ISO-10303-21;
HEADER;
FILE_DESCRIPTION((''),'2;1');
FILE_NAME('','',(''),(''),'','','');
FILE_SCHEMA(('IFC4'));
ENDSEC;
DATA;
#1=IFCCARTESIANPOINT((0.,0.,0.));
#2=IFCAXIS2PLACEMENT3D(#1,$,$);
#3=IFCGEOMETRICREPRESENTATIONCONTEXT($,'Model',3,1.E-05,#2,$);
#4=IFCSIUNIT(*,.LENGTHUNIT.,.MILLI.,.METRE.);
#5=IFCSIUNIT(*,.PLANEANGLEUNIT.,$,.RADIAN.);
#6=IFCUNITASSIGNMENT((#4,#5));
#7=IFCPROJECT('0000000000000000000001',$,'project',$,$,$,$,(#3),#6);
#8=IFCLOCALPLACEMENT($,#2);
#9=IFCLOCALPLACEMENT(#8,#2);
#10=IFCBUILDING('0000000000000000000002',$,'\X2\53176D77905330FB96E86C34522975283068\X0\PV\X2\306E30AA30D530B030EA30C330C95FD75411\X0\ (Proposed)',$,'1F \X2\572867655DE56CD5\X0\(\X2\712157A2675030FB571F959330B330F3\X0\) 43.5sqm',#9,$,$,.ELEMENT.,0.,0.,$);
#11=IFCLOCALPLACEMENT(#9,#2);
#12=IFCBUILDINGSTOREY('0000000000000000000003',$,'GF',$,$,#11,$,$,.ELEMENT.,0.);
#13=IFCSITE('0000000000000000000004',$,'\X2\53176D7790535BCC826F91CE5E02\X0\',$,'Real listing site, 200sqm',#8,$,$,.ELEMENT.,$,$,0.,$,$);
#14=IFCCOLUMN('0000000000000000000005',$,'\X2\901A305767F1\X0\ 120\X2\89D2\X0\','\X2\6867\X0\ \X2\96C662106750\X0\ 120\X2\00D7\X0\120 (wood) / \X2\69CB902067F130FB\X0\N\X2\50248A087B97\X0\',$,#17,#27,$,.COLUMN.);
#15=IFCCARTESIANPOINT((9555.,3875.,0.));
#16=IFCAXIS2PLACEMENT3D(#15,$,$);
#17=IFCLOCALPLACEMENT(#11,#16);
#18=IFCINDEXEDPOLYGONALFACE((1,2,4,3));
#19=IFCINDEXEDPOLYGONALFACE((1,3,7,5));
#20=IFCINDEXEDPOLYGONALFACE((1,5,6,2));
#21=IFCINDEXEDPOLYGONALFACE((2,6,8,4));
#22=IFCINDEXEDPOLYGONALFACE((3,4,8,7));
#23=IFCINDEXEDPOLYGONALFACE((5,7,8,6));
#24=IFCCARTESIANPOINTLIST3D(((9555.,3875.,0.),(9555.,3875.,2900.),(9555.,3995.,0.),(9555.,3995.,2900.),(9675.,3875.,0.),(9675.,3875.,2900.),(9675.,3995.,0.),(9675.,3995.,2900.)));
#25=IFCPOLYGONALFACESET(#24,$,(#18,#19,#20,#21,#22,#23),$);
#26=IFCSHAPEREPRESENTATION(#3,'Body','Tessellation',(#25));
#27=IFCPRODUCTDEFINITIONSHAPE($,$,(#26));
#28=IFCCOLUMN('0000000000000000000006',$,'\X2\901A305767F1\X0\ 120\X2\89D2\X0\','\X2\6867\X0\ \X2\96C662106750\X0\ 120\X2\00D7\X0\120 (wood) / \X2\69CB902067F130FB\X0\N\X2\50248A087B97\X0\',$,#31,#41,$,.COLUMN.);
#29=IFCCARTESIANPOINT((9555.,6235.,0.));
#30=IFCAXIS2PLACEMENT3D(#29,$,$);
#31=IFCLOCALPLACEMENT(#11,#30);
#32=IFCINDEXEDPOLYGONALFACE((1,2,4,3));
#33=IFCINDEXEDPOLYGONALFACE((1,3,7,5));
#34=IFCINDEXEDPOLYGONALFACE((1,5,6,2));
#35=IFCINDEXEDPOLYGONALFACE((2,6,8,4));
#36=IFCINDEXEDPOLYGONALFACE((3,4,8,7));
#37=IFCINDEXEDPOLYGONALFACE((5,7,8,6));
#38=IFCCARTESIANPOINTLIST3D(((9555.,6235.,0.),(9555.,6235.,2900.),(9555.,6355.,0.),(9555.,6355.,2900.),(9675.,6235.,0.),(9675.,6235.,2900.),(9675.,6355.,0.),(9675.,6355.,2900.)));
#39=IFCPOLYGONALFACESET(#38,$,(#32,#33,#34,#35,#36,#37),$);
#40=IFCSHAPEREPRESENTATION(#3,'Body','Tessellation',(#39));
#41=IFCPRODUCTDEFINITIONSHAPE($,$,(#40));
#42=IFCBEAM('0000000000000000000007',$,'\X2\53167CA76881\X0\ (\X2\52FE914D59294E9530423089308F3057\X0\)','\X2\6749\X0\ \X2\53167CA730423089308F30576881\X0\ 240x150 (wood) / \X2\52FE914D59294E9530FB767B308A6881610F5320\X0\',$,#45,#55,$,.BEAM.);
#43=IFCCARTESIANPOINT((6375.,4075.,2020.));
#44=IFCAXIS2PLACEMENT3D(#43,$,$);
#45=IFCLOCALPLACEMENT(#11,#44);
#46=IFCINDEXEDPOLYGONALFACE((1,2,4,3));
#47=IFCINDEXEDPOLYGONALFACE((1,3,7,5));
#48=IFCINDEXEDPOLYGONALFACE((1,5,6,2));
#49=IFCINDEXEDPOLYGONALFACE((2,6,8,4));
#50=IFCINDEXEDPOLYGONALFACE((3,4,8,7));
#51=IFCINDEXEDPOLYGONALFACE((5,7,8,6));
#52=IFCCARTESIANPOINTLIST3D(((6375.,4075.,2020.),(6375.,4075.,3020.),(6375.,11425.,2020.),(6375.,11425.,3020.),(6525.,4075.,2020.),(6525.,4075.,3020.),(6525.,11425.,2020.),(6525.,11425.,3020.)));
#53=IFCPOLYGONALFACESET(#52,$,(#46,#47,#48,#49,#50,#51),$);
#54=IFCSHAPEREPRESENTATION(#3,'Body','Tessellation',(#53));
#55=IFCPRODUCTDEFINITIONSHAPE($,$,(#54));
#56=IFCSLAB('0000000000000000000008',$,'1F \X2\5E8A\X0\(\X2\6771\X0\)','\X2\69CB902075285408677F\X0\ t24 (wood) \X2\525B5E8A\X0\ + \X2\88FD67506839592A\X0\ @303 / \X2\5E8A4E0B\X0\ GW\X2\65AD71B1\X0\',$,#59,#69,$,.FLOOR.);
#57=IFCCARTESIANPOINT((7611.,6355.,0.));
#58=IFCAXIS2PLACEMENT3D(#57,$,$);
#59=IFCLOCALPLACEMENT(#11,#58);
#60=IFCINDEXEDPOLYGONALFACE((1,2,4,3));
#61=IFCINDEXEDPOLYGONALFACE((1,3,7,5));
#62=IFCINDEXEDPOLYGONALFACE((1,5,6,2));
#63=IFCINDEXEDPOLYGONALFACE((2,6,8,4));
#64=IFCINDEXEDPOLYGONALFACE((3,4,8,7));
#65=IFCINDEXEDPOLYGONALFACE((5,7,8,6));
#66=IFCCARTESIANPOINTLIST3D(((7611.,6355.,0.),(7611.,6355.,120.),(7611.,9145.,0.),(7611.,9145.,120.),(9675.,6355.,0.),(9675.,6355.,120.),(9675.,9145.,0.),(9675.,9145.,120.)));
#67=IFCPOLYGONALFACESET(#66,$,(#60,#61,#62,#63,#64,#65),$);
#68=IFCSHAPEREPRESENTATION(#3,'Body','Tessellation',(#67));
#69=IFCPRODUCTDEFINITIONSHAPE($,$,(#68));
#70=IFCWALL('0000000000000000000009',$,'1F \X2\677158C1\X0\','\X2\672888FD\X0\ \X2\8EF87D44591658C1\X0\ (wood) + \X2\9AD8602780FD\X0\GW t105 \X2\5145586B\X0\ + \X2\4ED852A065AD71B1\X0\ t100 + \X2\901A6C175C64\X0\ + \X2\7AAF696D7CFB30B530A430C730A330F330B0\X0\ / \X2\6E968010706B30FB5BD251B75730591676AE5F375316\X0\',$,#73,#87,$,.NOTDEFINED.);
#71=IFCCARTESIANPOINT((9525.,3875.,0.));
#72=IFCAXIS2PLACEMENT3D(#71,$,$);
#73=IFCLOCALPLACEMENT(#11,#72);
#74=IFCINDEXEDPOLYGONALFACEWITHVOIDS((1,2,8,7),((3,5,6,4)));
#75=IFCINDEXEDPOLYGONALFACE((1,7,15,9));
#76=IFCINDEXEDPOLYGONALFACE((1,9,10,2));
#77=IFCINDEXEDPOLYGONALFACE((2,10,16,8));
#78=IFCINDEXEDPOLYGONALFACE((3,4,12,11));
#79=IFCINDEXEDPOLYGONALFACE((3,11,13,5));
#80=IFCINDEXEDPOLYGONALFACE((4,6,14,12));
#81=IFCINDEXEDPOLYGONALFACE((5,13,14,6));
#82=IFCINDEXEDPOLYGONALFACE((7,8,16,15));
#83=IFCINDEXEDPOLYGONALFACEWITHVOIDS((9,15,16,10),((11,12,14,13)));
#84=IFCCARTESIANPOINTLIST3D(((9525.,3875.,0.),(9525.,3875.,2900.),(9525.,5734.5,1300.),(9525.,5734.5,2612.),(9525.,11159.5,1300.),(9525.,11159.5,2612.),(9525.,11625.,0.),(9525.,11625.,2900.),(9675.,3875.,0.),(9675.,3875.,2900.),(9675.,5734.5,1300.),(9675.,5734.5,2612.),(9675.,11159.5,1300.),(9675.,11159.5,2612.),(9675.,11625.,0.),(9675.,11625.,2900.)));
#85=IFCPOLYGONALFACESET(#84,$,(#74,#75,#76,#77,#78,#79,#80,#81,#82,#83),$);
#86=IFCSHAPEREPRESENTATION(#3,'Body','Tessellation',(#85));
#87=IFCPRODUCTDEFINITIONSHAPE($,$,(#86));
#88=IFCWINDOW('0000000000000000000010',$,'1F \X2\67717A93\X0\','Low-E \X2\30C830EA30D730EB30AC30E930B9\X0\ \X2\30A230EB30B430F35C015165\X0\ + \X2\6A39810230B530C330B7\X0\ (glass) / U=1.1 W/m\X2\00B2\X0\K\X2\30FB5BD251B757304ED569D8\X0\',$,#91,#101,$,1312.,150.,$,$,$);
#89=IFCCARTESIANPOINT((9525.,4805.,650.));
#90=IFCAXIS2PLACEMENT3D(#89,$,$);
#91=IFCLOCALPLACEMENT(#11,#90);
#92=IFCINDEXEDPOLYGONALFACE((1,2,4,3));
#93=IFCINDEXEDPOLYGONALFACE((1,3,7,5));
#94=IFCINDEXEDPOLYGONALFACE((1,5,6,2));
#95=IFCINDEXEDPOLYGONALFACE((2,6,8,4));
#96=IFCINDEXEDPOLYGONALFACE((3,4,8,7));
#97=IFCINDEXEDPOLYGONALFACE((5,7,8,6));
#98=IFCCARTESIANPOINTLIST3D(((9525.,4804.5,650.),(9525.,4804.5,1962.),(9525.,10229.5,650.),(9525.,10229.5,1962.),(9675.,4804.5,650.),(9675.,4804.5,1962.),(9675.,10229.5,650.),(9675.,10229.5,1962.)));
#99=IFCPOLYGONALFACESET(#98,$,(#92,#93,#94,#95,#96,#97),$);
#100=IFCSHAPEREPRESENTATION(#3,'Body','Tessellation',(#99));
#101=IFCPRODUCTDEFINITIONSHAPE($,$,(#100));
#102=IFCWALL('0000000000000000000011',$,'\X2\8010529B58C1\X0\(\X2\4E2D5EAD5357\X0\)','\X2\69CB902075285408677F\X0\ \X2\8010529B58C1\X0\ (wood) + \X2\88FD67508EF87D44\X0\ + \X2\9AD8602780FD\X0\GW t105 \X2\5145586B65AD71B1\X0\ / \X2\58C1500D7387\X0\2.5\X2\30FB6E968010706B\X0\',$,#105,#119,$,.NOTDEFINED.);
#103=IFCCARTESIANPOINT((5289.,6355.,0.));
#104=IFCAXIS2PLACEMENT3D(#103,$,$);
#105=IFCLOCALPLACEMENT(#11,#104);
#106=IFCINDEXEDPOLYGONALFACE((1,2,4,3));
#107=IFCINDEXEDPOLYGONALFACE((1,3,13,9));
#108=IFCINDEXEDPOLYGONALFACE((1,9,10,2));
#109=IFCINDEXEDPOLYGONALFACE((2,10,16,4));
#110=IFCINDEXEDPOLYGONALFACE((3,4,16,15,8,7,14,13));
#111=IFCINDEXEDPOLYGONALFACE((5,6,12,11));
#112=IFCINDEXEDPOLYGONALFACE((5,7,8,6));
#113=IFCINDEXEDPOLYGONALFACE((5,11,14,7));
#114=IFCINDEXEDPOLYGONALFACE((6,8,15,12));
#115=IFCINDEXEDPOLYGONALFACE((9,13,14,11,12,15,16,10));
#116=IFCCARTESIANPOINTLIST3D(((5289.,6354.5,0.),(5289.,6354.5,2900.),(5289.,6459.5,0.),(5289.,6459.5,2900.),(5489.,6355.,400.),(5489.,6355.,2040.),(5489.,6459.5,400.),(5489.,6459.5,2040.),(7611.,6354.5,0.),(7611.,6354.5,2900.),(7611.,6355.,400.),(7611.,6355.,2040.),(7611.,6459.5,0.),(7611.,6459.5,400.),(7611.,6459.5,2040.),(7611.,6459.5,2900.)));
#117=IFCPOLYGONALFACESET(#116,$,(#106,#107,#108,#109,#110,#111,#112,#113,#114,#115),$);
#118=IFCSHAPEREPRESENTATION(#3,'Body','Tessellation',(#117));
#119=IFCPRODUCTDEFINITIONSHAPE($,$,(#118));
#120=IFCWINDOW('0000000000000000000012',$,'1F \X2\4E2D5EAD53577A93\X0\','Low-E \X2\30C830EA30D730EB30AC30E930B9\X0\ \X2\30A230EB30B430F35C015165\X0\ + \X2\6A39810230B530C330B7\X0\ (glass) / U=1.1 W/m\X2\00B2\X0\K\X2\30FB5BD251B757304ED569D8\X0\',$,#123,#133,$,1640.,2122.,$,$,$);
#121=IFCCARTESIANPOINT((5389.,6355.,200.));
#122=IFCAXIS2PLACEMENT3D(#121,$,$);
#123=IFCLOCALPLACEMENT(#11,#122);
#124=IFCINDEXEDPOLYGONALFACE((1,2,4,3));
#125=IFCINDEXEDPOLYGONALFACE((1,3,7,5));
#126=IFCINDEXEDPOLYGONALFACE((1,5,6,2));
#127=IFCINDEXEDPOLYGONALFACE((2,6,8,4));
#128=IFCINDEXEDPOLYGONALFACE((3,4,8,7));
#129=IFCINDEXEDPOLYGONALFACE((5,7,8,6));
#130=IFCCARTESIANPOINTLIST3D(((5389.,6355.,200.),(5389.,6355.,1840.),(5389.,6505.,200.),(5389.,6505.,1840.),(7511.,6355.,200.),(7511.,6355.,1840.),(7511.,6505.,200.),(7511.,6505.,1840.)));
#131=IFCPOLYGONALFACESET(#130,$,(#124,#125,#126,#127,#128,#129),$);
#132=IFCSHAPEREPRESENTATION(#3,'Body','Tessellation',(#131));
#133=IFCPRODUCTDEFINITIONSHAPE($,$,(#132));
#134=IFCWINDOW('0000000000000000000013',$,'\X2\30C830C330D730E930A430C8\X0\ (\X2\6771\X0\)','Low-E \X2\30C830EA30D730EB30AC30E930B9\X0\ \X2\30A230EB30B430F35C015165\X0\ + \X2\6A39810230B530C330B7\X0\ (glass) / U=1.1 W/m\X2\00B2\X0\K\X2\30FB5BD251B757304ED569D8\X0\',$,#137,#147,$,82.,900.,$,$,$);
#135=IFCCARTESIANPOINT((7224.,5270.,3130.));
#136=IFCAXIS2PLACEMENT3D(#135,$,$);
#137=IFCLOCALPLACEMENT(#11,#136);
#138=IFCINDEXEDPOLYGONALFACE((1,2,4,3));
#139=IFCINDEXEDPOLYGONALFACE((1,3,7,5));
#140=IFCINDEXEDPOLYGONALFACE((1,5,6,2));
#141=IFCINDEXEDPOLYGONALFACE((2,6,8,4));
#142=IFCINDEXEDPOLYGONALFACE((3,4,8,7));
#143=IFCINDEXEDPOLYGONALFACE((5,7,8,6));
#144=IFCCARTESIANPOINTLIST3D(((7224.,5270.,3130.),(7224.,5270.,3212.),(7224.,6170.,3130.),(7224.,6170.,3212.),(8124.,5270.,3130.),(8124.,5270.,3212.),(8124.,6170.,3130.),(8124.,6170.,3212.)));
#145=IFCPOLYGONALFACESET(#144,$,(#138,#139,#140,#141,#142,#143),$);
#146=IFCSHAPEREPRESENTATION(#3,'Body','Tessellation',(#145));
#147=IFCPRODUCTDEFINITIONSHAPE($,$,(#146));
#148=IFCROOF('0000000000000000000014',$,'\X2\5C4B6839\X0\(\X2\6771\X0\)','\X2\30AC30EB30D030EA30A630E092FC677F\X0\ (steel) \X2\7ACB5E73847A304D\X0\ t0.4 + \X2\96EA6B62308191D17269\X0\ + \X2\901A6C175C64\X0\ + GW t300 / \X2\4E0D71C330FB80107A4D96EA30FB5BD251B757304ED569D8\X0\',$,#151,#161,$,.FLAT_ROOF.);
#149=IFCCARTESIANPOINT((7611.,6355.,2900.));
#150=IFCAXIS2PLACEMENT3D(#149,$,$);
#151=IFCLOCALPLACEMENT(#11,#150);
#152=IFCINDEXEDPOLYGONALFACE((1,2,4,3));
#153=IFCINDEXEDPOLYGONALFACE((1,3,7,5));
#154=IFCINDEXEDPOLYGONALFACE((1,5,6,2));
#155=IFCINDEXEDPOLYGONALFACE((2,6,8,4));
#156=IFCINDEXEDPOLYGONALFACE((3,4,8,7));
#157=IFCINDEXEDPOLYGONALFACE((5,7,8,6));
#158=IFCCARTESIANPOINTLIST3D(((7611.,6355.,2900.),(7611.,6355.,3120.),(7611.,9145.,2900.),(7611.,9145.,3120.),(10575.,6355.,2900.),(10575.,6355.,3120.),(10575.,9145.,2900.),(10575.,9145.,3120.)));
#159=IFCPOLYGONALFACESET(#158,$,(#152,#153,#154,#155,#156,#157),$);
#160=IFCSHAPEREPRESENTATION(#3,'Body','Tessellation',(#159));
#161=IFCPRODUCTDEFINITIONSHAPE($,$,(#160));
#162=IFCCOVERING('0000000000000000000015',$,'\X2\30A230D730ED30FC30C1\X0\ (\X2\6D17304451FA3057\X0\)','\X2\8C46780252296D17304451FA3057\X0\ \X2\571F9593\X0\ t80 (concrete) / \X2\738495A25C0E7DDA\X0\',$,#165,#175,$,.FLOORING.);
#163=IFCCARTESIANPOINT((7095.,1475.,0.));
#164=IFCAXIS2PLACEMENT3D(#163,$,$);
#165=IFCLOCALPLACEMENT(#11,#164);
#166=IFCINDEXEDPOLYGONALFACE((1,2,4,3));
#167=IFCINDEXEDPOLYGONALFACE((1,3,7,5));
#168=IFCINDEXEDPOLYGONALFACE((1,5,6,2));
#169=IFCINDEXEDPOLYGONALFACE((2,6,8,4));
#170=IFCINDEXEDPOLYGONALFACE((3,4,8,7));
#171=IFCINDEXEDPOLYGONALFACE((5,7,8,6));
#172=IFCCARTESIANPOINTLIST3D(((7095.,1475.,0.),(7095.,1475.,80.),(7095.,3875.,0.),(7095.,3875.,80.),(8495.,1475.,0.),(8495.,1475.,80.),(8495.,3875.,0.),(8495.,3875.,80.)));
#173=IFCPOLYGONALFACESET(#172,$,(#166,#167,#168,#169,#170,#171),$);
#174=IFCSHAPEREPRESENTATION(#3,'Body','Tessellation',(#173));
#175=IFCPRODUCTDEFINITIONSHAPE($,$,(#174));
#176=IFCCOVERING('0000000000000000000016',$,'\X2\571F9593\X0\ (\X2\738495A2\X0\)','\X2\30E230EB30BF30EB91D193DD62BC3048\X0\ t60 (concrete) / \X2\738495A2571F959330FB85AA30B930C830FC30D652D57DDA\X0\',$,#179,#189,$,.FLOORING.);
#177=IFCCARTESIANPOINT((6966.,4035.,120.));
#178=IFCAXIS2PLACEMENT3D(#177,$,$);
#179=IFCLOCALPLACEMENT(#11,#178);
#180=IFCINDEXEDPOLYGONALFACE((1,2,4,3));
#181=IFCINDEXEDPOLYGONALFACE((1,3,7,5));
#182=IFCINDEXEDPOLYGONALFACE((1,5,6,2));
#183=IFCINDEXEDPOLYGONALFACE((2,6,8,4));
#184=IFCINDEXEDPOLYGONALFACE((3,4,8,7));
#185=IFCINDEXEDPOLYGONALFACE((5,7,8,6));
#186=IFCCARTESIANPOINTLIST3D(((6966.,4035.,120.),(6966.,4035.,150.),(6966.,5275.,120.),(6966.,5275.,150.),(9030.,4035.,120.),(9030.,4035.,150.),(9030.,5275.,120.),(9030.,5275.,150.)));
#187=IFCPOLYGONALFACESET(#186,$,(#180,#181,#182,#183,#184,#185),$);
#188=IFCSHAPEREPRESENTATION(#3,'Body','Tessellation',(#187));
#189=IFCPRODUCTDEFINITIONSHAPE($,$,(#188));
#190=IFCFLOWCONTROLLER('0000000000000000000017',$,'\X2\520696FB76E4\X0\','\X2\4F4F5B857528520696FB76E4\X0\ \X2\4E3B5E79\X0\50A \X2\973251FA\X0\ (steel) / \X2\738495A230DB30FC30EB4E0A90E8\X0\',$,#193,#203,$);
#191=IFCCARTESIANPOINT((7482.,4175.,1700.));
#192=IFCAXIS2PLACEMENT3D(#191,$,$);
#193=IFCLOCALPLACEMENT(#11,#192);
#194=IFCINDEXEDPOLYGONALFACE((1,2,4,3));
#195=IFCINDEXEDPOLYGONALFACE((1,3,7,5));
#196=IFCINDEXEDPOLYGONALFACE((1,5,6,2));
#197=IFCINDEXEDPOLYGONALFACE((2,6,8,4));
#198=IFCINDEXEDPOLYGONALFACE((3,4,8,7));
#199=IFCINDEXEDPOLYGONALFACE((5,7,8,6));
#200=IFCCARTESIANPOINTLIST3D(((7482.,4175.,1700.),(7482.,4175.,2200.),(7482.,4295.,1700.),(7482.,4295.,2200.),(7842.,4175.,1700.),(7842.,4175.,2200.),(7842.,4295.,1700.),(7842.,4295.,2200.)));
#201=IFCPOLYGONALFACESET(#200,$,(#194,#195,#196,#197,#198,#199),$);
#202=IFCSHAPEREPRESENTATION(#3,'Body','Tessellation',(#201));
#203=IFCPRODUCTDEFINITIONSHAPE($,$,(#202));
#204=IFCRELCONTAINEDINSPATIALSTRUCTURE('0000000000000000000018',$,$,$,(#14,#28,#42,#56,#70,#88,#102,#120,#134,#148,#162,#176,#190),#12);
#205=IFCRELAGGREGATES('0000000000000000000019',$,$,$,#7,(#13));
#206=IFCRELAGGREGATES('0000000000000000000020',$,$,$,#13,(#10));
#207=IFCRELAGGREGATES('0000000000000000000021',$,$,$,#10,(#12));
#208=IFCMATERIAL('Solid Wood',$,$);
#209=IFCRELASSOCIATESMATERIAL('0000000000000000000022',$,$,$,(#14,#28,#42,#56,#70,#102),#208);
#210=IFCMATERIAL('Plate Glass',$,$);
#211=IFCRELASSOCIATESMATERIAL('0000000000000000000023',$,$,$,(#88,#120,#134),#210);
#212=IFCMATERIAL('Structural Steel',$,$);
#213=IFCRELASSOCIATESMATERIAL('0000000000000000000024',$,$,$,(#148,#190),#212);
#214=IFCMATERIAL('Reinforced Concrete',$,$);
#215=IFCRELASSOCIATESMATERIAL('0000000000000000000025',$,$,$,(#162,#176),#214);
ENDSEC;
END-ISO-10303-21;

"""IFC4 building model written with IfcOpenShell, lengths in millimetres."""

from ifc_helpers import new_model, si_unit, frame, frame_2d, origin, place, context, project, spatial, rectangle, extrude, material, element, fill, save


model = new_model("IFC4")

# Units and contexts
model_context = context("Model", 3, precision=1e-05, world=origin())
ifc_project = project(units=[si_unit("LENGTHUNIT", "METRE", prefix="MILLI"), si_unit("PLANEANGLEUNIT", "RADIAN")], contexts=[model_context])

# Site, building, storey
site_placement = place(None, origin())
site = spatial("IfcSite", under=ifc_project, at=site_placement, Name="北海道富良野市", ObjectType="Real listing site, 200sqm", CompositionType="ELEMENT", RefElevation=0.0)
building_placement = place(site_placement, origin())
building = spatial("IfcBuilding", under=site, at=building_placement, Name="北海道・雨水利用とPVのオフグリッド志向 (Proposed)", ObjectType="1F 在来工法(無垢材・土間コン) 43.5sqm", CompositionType="ELEMENT", ElevationOfRefHeight=0.0, ElevationOfTerrain=0.0)
storey_placement = place(building_placement, origin())
storey = spatial("IfcBuildingStorey", under=building, at=storey_placement, Name="GF", CompositionType="ELEMENT", Elevation=0.0)

# Columns
ifc_material_1 = material(Name="Solid Wood")
column_1_placement = place(storey_placement, frame((9555.0, 3875.0, 0.0)))
element("IfcColumn", 1, at=column_1_placement, inside=storey, material=ifc_material_1, Name="通し柱 120角", Description="桧 集成材 120×120 (wood) / 構造柱・N値計算", PredefinedType="COLUMN", context=model_context, shape_type="SweptSolid", body=[
    extrude(rectangle(XDim=120.0, YDim=120.0, at=frame_2d((60.0, 60.0))), frame((9555.0, 3875.0, 0.0)), (0.0, 0.0, 1.0), 2900.0),
])
column_2_placement = place(storey_placement, frame((9555.0, 6235.0, 0.0)))
element("IfcColumn", 2, at=column_2_placement, inside=storey, material=ifc_material_1, Name="通し柱 120角", Description="桧 集成材 120×120 (wood) / 構造柱・N値計算", PredefinedType="COLUMN", context=model_context, shape_type="SweptSolid", body=[
    extrude(rectangle(XDim=120.0, YDim=120.0, at=frame_2d((60.0, 60.0))), frame((9555.0, 6235.0, 0.0)), (0.0, 0.0, 1.0), 2900.0),
])

# Beam
beam_1_placement = place(storey_placement, frame((6375.0, 4075.0, 2020.0)))
element("IfcBeam", 3, at=beam_1_placement, inside=storey, material=ifc_material_1, Name="化粧梁 (勾配天井あらわし)", Description="杉 化粧あらわし梁 240x150 (wood) / 勾配天井・登り梁意匠", PredefinedType="BEAM", context=model_context, shape_type="SweptSolid", body=[
    extrude(rectangle(XDim=150.0, YDim=7350.0, at=frame_2d((75.0, 3675.0))), frame((6375.0, 4075.0, 2020.0)), (0.0, 0.0, 1.0), 1000.0),
])

# Slab
slab_placement = place(storey_placement, frame((7611.0, 6355.0, 0.0)))
element("IfcSlab", 4, at=slab_placement, inside=storey, material=ifc_material_1, Name="1F 床(東)", Description="構造用合板 t24 (wood) 剛床 + 製材根太 @303 / 床下 GW断熱", PredefinedType="FLOOR", context=model_context, shape_type="SweptSolid", body=[
    extrude(rectangle(XDim=2064.0, YDim=2790.0, at=frame_2d((1032.0, 1395.0))), frame((7611.0, 6355.0, 0.0)), (0.0, 0.0, 1.0), 120.0),
])

# Walls, openings, windows
wall_1_placement = place(storey_placement, frame((9525.0, 3875.0, 0.0)))
wall_1 = element("IfcWall", 5, at=wall_1_placement, inside=storey, material=ifc_material_1, Name="1F 東壁", Description="木製 軸組外壁 (wood) + 高性能GW t105 充填 + 付加断熱 t100 + 通気層 + 窯業系サイディング / 準耐火・寒冷地外皮強化", PredefinedType="NOTDEFINED", context=model_context, shape_type="SweptSolid", body=[
    extrude(rectangle(XDim=150.0, YDim=7750.0, at=frame_2d((75.0, 3875.0))), frame((9525.0, 3875.0, 0.0)), (0.0, 0.0, 1.0), 2900.0),
])
opening_1_placement = place(storey_placement, frame((9525.0, 4805.0, 650.0)))
opening_1 = element("IfcOpeningElement", 6, at=opening_1_placement, cuts=wall_1, PredefinedType="NOTDEFINED", context=model_context, shape_type="SweptSolid", body=[
    extrude(rectangle(XDim=150.0, YDim=5425.0, at=frame_2d((75.0, 2712.0))), frame((9525.0, 4805.0, 650.0)), (0.0, 0.0, 1.0), 1312.0),
])
ifc_material_2 = material(Name="Plate Glass")
window_1_placement = place(storey_placement, frame((9525.0, 4805.0, 650.0)))
window_1 = element("IfcWindow", 7, at=window_1_placement, inside=storey, material=ifc_material_2, Name="1F 東窓", Description="Low-E トリプルガラス アルゴン封入 + 樹脂サッシ (glass) / U=1.1 W/m²K・寒冷地仕様", OverallHeight=1312.0, OverallWidth=150.0, context=model_context, shape_type="SweptSolid", body=[
    extrude(rectangle(XDim=150.0, YDim=5425.0, at=frame_2d((75.0, 2712.0))), frame((9525.0, 4805.0, 650.0)), (0.0, 0.0, 1.0), 1312.0),
])
fill(opening_1, window_1)
wall_2_placement = place(storey_placement, frame((5289.0, 6355.0, 0.0)))
wall_2 = element("IfcWall", 8, at=wall_2_placement, inside=storey, material=ifc_material_1, Name="耐力壁(中庭南)", Description="構造用合板 耐力壁 (wood) + 製材軸組 + 高性能GW t105 充填断熱 / 壁倍率2.5・準耐火", PredefinedType="NOTDEFINED", context=model_context, shape_type="SweptSolid", body=[
    extrude(rectangle(XDim=2322.0, YDim=105.0, at=frame_2d((1161.0, 52.0))), frame((5289.0, 6355.0, 0.0)), (0.0, 0.0, 1.0), 2900.0),
])
opening_2_placement = place(storey_placement, frame((5389.0, 6355.0, 200.0)))
opening_2 = element("IfcOpeningElement", 9, at=opening_2_placement, cuts=wall_2, PredefinedType="NOTDEFINED", context=model_context, shape_type="SweptSolid", body=[
    extrude(rectangle(XDim=2122.0, YDim=150.0, at=frame_2d((1061.0, 75.0))), frame((5389.0, 6355.0, 200.0)), (0.0, 0.0, 1.0), 1640.0),
])
window_2_placement = place(storey_placement, frame((5389.0, 6355.0, 200.0)))
window_2 = element("IfcWindow", 10, at=window_2_placement, inside=storey, material=ifc_material_2, Name="1F 中庭南窓", Description="Low-E トリプルガラス アルゴン封入 + 樹脂サッシ (glass) / U=1.1 W/m²K・寒冷地仕様", OverallHeight=1640.0, OverallWidth=2122.0, context=model_context, shape_type="SweptSolid", body=[
    extrude(rectangle(XDim=2122.0, YDim=150.0, at=frame_2d((1061.0, 75.0))), frame((5389.0, 6355.0, 200.0)), (0.0, 0.0, 1.0), 1640.0),
])
fill(opening_2, window_2)

# Window
window_3_placement = place(storey_placement, frame((7224.0, 5270.0, 3130.0)))
element("IfcWindow", 11, at=window_3_placement, inside=storey, material=ifc_material_2, Name="トップライト (東)", Description="Low-E トリプルガラス アルゴン封入 + 樹脂サッシ (glass) / U=1.1 W/m²K・寒冷地仕様", OverallHeight=82.0, OverallWidth=900.0, context=model_context, shape_type="SweptSolid", body=[
    extrude(rectangle(XDim=900.0, YDim=900.0, at=frame_2d((450.0, 450.0))), frame((7224.0, 5270.0, 3130.0)), (0.0, 0.0, 1.0), 82.0),
])

# Roof
ifc_material_3 = material(Name="Structural Steel")
roof_placement = place(storey_placement, frame((7611.0, 6355.0, 2900.0)))
element("IfcRoof", 12, at=roof_placement, inside=storey, material=ifc_material_3, Name="屋根(東)", Description="ガルバリウム鋼板 (steel) 立平葺き t0.4 + 雪止め金物 + 通気層 + GW t300 / 不燃・耐積雪・寒冷地仕様", PredefinedType="FLAT_ROOF", context=model_context, shape_type="SweptSolid", body=[
    extrude(rectangle(XDim=2964.0, YDim=2790.0, at=frame_2d((1482.0, 1395.0))), frame((7611.0, 6355.0, 2900.0)), (0.0, 0.0, 1.0), 220.0),
])

# Coverings
ifc_material_4 = material(Name="Reinforced Concrete")
covering_1_placement = place(storey_placement, frame((7095.0, 1475.0, 0.0)))
element("IfcCovering", 13, at=covering_1_placement, inside=storey, material=ifc_material_4, Name="アプローチ (洗い出し)", Description="豆砂利洗い出し 土間 t80 (concrete) / 玄関導線", PredefinedType="FLOORING", context=model_context, shape_type="SweptSolid", body=[
    extrude(rectangle(XDim=1400.0, YDim=2400.0, at=frame_2d((700.0, 1200.0))), frame((7095.0, 1475.0, 0.0)), (0.0, 0.0, 1.0), 80.0),
])
covering_2_placement = place(storey_placement, frame((6966.0, 4035.0, 120.0)))
element("IfcCovering", 14, at=covering_2_placement, inside=storey, material=ifc_material_4, Name="土間 (玄関)", Description="モルタル金鏝押え t60 (concrete) / 玄関土間・薪ストーブ動線", PredefinedType="FLOORING", context=model_context, shape_type="SweptSolid", body=[
    extrude(rectangle(XDim=2064.0, YDim=1240.0, at=frame_2d((1032.0, 620.0))), frame((6966.0, 4035.0, 120.0)), (0.0, 0.0, 1.0), 30.0),
])

# Flow controller
flow_controller_placement = place(storey_placement, frame((7482.0, 4175.0, 1700.0)))
element("IfcFlowController", 15, at=flow_controller_placement, inside=storey, material=ifc_material_3, Name="分電盤", Description="住宅用分電盤 主幹50A 露出 (steel) / 玄関ホール上部", context=model_context, shape_type="SweptSolid", body=[
    extrude(rectangle(XDim=360.0, YDim=120.0, at=frame_2d((180.0, 60.0))), frame((7482.0, 4175.0, 1700.0)), (0.0, 0.0, 1.0), 500.0),
])

save(model, "model.ifc")
